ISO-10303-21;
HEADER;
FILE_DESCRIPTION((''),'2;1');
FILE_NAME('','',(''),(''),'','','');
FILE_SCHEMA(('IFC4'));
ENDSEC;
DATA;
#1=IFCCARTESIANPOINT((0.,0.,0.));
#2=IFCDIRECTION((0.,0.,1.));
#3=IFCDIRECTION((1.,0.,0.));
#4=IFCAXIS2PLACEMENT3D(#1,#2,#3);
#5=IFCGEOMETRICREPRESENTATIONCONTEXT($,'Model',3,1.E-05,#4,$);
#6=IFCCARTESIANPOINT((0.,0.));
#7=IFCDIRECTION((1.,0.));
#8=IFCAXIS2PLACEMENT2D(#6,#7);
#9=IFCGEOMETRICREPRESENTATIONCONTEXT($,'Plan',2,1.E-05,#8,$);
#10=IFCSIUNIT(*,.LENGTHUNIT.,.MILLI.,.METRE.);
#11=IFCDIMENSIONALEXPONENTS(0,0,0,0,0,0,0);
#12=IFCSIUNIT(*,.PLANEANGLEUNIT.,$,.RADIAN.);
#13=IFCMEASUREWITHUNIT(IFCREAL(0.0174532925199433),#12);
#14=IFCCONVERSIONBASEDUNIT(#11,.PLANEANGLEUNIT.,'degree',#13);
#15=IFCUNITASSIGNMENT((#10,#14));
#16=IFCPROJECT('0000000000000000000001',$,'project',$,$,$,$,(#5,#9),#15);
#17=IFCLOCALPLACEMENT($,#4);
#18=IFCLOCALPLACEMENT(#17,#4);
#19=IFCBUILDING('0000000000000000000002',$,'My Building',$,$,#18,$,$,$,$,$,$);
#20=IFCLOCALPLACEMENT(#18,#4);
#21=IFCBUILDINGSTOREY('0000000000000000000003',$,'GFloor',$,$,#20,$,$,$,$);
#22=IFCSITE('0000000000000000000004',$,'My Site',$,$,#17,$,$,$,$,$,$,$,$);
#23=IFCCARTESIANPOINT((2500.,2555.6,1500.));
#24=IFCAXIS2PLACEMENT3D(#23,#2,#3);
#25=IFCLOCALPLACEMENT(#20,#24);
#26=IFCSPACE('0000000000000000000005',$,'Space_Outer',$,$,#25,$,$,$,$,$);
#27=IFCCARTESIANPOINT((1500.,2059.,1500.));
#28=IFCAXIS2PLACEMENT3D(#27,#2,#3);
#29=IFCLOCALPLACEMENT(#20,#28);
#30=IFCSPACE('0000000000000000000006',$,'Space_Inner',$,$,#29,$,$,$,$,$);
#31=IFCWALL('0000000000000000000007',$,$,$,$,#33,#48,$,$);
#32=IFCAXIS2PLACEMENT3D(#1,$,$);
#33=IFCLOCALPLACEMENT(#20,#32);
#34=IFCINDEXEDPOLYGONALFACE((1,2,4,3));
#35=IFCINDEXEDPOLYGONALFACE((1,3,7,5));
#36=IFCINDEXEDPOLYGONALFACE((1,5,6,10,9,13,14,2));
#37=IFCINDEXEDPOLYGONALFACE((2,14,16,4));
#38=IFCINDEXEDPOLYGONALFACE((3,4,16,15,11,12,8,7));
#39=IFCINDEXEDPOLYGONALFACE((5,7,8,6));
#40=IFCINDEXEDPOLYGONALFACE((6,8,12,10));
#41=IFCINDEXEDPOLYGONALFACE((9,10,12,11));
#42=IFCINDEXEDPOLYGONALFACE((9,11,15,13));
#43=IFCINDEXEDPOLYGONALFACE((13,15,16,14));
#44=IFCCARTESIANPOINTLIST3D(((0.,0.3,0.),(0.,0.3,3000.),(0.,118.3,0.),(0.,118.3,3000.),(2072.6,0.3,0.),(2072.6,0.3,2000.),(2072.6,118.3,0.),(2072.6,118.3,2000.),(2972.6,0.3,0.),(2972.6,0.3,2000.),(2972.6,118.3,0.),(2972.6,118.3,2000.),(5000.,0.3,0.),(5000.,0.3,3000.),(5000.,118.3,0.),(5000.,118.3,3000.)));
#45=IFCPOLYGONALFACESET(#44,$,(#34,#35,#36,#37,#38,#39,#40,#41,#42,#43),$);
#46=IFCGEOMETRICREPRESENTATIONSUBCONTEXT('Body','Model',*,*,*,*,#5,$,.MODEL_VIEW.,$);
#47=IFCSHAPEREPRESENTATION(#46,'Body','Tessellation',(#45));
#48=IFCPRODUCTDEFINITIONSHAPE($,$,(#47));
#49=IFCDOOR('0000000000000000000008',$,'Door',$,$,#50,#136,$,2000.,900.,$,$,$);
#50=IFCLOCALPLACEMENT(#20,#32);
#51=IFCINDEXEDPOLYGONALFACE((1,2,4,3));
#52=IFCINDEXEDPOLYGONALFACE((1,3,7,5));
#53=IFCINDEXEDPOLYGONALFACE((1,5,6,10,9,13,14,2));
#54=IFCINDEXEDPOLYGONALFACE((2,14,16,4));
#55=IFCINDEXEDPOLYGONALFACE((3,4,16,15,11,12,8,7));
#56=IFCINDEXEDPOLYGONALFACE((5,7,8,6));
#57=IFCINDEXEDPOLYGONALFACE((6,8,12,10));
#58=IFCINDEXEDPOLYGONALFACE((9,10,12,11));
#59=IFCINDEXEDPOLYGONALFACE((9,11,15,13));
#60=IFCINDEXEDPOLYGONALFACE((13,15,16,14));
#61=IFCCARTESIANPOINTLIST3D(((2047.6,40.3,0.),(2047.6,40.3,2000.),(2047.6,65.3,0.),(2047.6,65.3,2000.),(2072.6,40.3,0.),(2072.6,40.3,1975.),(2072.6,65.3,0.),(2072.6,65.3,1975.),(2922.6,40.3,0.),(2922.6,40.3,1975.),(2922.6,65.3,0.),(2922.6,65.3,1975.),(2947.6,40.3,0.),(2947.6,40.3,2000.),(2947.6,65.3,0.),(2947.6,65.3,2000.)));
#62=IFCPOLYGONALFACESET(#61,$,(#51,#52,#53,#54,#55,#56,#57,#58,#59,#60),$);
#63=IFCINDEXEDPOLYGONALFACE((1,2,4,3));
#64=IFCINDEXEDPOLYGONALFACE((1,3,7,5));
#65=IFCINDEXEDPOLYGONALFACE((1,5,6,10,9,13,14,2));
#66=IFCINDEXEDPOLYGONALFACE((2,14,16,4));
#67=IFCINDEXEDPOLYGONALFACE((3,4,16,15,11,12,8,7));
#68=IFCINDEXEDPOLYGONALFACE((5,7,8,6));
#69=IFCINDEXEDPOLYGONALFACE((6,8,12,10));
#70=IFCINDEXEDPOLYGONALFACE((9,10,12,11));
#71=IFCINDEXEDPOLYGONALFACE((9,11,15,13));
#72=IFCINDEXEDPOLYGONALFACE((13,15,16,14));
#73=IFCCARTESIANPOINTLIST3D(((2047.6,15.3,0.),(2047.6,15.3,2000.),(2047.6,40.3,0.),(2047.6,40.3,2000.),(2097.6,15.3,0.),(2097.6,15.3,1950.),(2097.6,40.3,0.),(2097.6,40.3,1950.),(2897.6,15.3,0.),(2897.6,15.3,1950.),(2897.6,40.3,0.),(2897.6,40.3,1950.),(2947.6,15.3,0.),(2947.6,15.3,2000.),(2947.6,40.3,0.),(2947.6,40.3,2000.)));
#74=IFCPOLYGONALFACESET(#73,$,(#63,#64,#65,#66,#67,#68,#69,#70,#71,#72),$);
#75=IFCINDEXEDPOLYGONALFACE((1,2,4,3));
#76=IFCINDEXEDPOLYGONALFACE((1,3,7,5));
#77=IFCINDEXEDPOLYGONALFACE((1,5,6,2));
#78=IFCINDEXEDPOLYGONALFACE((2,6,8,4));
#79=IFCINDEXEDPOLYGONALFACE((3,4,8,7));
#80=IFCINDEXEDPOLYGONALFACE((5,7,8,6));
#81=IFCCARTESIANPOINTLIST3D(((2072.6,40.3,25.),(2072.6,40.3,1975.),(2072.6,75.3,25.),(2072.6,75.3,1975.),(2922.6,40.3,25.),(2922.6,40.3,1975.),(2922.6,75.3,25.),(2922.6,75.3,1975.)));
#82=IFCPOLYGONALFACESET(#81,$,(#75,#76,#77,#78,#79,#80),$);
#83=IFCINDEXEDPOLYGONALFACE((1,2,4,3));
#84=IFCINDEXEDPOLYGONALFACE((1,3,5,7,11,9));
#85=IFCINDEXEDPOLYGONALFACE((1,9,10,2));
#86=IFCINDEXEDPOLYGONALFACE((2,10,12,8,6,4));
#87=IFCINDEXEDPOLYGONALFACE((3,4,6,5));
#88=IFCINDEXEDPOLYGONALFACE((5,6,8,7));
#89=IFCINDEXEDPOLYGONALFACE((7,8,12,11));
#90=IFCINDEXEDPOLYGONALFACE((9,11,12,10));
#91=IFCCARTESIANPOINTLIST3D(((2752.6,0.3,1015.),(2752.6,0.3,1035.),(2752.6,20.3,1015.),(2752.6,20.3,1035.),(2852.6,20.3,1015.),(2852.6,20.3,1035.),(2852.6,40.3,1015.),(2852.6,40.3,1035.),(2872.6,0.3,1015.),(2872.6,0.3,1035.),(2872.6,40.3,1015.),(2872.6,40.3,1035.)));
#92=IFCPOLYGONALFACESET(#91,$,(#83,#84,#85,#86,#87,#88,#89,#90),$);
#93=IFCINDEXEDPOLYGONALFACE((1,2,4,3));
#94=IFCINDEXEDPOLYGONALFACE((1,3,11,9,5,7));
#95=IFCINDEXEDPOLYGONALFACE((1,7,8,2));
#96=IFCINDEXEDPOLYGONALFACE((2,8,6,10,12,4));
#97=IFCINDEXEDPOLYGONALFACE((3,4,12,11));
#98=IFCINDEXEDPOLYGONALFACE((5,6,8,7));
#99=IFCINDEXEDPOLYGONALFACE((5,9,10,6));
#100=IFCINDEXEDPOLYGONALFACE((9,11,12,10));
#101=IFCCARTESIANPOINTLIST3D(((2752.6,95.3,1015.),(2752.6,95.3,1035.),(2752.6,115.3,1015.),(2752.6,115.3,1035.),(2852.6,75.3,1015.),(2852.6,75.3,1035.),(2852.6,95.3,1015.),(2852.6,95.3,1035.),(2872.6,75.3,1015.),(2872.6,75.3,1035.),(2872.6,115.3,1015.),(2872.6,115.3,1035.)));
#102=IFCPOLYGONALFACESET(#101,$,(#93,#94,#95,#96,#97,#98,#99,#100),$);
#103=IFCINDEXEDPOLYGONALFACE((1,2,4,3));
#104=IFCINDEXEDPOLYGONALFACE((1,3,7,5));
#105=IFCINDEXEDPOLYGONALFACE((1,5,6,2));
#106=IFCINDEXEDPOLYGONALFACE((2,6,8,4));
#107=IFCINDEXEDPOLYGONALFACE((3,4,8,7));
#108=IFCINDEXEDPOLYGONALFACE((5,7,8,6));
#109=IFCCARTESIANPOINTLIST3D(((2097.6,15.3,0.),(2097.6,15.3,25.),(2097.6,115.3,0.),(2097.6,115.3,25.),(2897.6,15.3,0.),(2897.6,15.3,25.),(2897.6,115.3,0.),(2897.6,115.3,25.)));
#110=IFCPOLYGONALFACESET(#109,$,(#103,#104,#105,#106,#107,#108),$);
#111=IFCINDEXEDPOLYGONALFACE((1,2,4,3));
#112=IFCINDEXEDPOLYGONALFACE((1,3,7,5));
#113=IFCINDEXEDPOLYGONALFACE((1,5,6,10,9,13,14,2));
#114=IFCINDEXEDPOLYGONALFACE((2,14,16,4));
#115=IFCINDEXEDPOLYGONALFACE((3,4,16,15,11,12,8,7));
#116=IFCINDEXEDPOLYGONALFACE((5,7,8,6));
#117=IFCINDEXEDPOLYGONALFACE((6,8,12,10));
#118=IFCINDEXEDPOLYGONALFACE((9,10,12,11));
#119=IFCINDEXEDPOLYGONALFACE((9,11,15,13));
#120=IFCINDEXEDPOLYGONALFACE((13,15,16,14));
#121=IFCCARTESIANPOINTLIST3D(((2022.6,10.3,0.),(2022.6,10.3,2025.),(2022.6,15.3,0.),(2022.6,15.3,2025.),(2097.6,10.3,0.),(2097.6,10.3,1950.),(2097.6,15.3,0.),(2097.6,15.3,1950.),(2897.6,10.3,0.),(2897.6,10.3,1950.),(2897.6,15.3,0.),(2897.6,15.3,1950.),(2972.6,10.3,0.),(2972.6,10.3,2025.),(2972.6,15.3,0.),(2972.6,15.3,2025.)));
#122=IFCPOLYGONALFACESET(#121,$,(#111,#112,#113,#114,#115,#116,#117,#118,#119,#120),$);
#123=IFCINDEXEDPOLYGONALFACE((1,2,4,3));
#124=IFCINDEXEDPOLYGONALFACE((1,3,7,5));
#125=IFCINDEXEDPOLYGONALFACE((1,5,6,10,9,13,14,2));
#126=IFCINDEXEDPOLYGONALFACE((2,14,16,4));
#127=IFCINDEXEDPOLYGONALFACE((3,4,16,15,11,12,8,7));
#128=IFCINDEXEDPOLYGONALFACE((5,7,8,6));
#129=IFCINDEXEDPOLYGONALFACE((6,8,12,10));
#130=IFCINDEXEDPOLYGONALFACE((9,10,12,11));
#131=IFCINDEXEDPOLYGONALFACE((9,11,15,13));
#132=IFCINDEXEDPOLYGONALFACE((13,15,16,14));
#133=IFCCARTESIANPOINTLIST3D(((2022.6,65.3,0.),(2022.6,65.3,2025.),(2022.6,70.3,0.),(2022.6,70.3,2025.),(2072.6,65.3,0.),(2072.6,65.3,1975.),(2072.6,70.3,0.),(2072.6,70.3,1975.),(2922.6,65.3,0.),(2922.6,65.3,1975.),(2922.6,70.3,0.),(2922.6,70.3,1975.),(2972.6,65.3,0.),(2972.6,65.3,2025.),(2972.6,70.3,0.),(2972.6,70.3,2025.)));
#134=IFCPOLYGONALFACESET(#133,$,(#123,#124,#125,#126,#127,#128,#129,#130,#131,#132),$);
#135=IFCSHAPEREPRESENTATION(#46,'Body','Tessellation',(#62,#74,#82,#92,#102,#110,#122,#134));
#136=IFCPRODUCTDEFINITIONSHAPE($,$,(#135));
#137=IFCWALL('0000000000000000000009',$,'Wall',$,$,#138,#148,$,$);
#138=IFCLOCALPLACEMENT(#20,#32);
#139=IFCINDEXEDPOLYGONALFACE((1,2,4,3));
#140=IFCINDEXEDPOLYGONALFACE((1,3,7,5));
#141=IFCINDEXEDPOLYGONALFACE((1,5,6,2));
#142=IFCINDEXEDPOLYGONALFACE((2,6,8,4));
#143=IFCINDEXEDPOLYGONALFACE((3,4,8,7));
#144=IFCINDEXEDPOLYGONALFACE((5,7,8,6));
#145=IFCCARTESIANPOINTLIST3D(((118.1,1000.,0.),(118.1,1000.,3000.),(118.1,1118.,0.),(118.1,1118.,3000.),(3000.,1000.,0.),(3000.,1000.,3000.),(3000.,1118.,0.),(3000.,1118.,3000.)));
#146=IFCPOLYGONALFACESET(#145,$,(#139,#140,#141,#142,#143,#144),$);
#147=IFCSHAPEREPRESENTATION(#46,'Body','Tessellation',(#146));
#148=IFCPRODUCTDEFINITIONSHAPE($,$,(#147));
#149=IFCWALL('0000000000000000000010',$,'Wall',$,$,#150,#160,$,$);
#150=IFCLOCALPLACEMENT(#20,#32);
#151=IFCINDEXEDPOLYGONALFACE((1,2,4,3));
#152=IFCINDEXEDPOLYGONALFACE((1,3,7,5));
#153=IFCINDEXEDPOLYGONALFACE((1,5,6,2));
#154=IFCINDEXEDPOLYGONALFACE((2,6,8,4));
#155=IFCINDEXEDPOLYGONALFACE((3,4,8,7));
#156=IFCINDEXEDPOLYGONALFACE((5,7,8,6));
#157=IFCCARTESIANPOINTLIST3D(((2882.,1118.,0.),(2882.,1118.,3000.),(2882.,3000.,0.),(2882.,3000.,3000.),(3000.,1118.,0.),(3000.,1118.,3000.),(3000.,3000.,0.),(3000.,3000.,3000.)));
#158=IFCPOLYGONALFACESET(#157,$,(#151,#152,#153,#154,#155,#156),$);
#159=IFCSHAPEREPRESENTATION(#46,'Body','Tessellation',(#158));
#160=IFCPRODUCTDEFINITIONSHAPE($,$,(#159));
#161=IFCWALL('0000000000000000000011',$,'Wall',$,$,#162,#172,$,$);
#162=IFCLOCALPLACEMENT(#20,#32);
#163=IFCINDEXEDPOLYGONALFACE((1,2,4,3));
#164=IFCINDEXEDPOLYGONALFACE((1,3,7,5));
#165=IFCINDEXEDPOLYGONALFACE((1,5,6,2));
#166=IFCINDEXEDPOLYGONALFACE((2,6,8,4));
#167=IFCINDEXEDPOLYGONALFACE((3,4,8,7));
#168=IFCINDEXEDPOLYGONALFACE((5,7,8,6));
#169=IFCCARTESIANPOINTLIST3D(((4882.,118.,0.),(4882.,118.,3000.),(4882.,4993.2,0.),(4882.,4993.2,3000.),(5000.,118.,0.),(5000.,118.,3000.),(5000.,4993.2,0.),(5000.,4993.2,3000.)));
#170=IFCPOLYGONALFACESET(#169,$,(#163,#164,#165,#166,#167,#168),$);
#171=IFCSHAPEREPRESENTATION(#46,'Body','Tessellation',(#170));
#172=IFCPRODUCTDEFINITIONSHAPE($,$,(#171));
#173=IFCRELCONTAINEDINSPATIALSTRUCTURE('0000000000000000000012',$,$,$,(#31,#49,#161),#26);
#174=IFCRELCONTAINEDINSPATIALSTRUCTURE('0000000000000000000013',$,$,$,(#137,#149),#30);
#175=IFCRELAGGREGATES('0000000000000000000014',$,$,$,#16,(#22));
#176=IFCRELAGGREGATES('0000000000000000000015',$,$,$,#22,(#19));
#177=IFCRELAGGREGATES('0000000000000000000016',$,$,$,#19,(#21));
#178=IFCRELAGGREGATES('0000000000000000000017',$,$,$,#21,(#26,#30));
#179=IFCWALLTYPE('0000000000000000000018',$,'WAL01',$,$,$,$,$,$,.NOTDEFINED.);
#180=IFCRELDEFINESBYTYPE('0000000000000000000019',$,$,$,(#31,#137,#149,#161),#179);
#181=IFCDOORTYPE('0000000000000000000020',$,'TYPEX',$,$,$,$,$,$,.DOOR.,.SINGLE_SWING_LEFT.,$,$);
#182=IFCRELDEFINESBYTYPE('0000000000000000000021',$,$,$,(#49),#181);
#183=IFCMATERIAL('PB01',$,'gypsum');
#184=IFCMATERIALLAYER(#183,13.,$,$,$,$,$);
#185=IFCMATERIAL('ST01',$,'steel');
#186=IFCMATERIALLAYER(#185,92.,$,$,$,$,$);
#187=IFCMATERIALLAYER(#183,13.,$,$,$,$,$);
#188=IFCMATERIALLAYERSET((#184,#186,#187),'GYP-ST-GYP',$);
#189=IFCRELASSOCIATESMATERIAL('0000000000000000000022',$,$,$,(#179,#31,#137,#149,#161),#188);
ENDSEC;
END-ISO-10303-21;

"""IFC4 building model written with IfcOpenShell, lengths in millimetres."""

from ifc_helpers import new_model, entity, si_unit, converted_unit, frame, origin_with_axes, origin_2d_with_axis, place, context, subcontext, project, spatial, line, indexed_curve, outline, extrude, shape, source, transform, mapped, material, layer, layer_set, layer_usage, type_object, type_shapes, element, fill, save


model = new_model("IFC4")

# Units and contexts
model_context = context("Model", 3, precision=1e-05, world=origin_with_axes())
plan_context = context("Plan", 2, precision=1e-05, world=origin_2d_with_axis())
body_context_1 = subcontext(model_context, "Body", "Model", "MODEL_VIEW")
body_context_2 = subcontext(plan_context, "Body", "Plan", "PLAN_VIEW")
ifc_project = project(units=[si_unit("LENGTHUNIT", "METRE", prefix="MILLI"), converted_unit("PLANEANGLEUNIT", "degree", entity("IfcReal", 0.0174532925199433), si_unit("PLANEANGLEUNIT", "RADIAN"), dimensions=[0, 0, 0, 0, 0, 0, 0])], contexts=[model_context, plan_context])

# Site, building, storey
site_placement = place(None, origin_with_axes())
site = spatial("IfcSite", under=ifc_project, at=site_placement, Name="My Site")
building_placement = place(site_placement, origin_with_axes())
building = spatial("IfcBuilding", under=site, at=building_placement, Name="My Building")
storey_placement = place(building_placement, origin_with_axes())
storey = spatial("IfcBuildingStorey", under=building, at=storey_placement, Name="GFloor")

# Shared definitions
space_1_placement = place(storey_placement, frame((2500.0, 2555.6, 1500.0), z_axis=(0.0, 0.0, 1.0), x_axis=(1.0, 0.0, 0.0)))
space_1 = spatial("IfcSpace", under=storey, at=space_1_placement, Name="Space_Outer")

# Wall, opening, door
ifc_material_1 = material(Name="PB01", Category="gypsum")
ifc_layer_1 = layer(ifc_material_1, 13.0)
ifc_material_2 = material(Name="ST01", Category="steel")
ifc_layer_2 = layer(ifc_material_2, 92.0)
ifc_layer_3 = layer(ifc_material_1, 13.0)
ifc_layer_set_1 = layer_set([ifc_layer_1, ifc_layer_2, ifc_layer_3], Name="GYP-ST-GYP")
ifc_layer_usage_1 = layer_usage(ifc_layer_set_1, "AXIS2", "POSITIVE", 0.0)
wall_type_1 = type_object("IfcWallType", Name="WAL01", PredefinedType="NOTDEFINED", material=ifc_layer_set_1)
wall_1_placement = place(space_1_placement, frame((-2500.0, -2555.3, -1500.0), z_axis=(0.0, 0.0, 1.0), x_axis=(1.0, 0.0, 0.0)))
wall_1 = element("IfcWall", 1, at=wall_1_placement, inside=space_1, type_object=wall_type_1, material=ifc_layer_usage_1, context=body_context_1, shape_type="SweptSolid", body=[
    extrude(outline(indexed_curve([(0.0, 0.0), (0.0, 118.0), (5000.0, 118.0), (5000.0, 0.0), (0.0, 0.0)], self_intersect=False)), origin_with_axes(), (0.0, 0.0, 1.0), 3000.0),
])
shared_shape_1 = source(origin_with_axes(), body_context_1, "Body", "SweptSolid", [
    extrude(outline(indexed_curve([(0.0, 0.0), (900.0, 0.0), (900.0, 2000.0), (0.0, 2000.0)], segments=[line(1, 2, 3, 4, 1)])), frame((0.0, -600.0, 0.0), z_axis=(0.0, -1.0, 0.0), x_axis=(1.0, 0.0, 0.0)), (0.0, 0.0, -1.0), 1200.0),
])
opening_placement = place(wall_1_placement, frame((2072.6, 0.0, 0.0), z_axis=(0.0, 0.0, 1.0), x_axis=(1.0, 0.0, 0.0)))
opening = element("IfcOpeningElement", 2, at=opening_placement, cuts=wall_1, PredefinedType="OPENING", context=body_context_1, shape_type="MappedRepresentation", body=[
    mapped(shared_shape_1, transform((0.0, 0.0, 0.0), x_axis=(1.0, 0.0, 0.0), y_axis=(0.0, 1.0, 0.0), z_axis=(0.0, 0.0, 1.0), scale=1.0)),
])
door_type = type_object("IfcDoorType", Name="TYPEX", OperationType="SINGLE_SWING_LEFT", PredefinedType="DOOR")
shared_shape_2 = source(origin_with_axes(), body_context_1, "Body", "SweptSolid", [
    extrude(outline(indexed_curve([(0.0, 0.0), (0.0, 2000.0), (900.0, 2000.0), (900.0, 0.0), (875.0, 0.0), (875.0, 1975.0), (25.0, 1975.0), (25.0, 0.0)], segments=[line(1, 2, 3, 4, 5, 6, 7, 8, 1)])), frame((0.0, 25.0, 0.0), z_axis=(0.0, -1.0, 0.0), x_axis=(1.0, 0.0, 0.0)), (0.0, 0.0, -1.0), 25.0),
    extrude(outline(indexed_curve([(0.0, 0.0), (0.0, 2000.0), (900.0, 2000.0), (900.0, 0.0), (850.0, 0.0), (850.0, 1950.0), (50.0, 1950.0), (50.0, 0.0)], segments=[line(1, 2, 3, 4, 5, 6, 7, 8, 1)])), frame((0.0, 0.0, 0.0), z_axis=(0.0, -1.0, 0.0), x_axis=(1.0, 0.0, 0.0)), (0.0, 0.0, -1.0), 25.0),
    extrude(outline(indexed_curve([(0.0, 0.0), (850.0, 0.0), (850.0, 35.0), (0.0, 35.0)], segments=[line(1, 2, 3, 4, 1)])), frame((25.0, 25.0, 25.0), z_axis=(0.0, 0.0, 1.0), x_axis=(1.0, 0.0, 0.0)), (0.0, 0.0, 1.0), 1950.0),
    extrude(outline(indexed_curve([(0.0, 0.0), (0.0, -40.0), (-120.0, -40.0), (-120.0, -20.0), (-20.0, -20.0), (-20.0, 0.0)], segments=[line(1, 2, 3, 4, 5, 6, 1)])), frame((825.0, 25.0, 1015.0), z_axis=(0.0, 0.0, 1.0), x_axis=(1.0, 0.0, 0.0)), (0.0, 0.0, 1.0), 20.0),
    extrude(outline(indexed_curve([(0.0, 0.0), (0.0, 40.0), (-120.0, 40.0), (-120.0, 20.0), (-20.0, 20.0), (-20.0, 0.0)], segments=[line(1, 2, 3, 4, 5, 6, 1)])), frame((825.0, 60.0, 1015.0), z_axis=(0.0, 0.0, 1.0), x_axis=(1.0, 0.0, 0.0)), (0.0, 0.0, 1.0), 20.0),
    extrude(outline(indexed_curve([(0.0, 0.0), (800.0, 0.0), (800.0, 100.0), (0.0, 100.0)], segments=[line(1, 2, 3, 4, 1)])), frame((50.0, 0.0, 0.0), z_axis=(0.0, 0.0, 1.0), x_axis=(1.0, 0.0, 0.0)), (0.0, 0.0, 1.0), 25.0),
    extrude(outline(indexed_curve([(0.0, 0.0), (0.0, 2025.0), (950.0, 2025.0), (950.0, 0.0), (875.0, 0.0), (875.0, 1950.0), (75.0, 1950.0), (75.0, 0.0)], segments=[line(1, 2, 3, 4, 5, 6, 7, 8, 1)])), frame((-25.0, -5.0, 0.0), z_axis=(0.0, -1.0, 0.0), x_axis=(1.0, 0.0, 0.0)), (0.0, 0.0, -1.0), 5.0),
    extrude(outline(indexed_curve([(0.0, 0.0), (0.0, 2025.0), (950.0, 2025.0), (950.0, 0.0), (900.0, 0.0), (900.0, 1975.0), (50.0, 1975.0), (50.0, 0.0)], segments=[line(1, 2, 3, 4, 5, 6, 7, 8, 1)])), frame((-25.0, 50.0, 0.0), z_axis=(0.0, -1.0, 0.0), x_axis=(1.0, 0.0, 0.0)), (0.0, 0.0, -1.0), 5.0),
])
shared_shape_3 = source(origin_with_axes(), body_context_2, "Body", "Curve2D", [
    entity("IfcIndexedPolyCurve", entity("IfcCartesianPointList2D", [[0.0, 0.0], [0.0, 50.0], [25.0, 50.0], [25.0, 25.0], [50.0, 25.0], [50.0, 0.0]]), [entity("IfcLineIndex", [1, 2, 3, 4, 5, 6, 1])]),
    entity("IfcIndexedPolyCurve", entity("IfcCartesianPointList2D", [[900.0, 0.0], [900.0, 50.0], [875.0, 50.0], [875.0, 25.0], [850.0, 25.0], [850.0, 0.0]]), [entity("IfcLineIndex", [1, 2, 3, 4, 5, 6, 1])]),
    entity("IfcTrimmedCurve", entity("IfcEllipse", entity("IfcAxis2Placement2D", entity("IfcCartesianPoint", [60.0, 50.0]), entity("IfcDirection", [1.0, 0.0])), 815.0, 850.0), [entity("IfcCartesianPoint", [875.0, 50.0])], [entity("IfcCartesianPoint", [60.0, 900.0])], True, "CARTESIAN"),
    entity("IfcIndexedPolyCurve", entity("IfcCartesianPointList2D", [[25.0, 50.0], [60.0, 50.0], [60.0, 900.0], [25.0, 900.0]]), [entity("IfcLineIndex", [1, 2, 3, 4, 1])]),
])
type_shapes(door_type, [shared_shape_2, shared_shape_3])
door_1_placement = place(opening_placement, frame((-25.0, 15.0, 0.0), z_axis=(0.0, 0.0, 1.0), x_axis=(1.0, 0.0, 0.0)))
door_1 = element("IfcDoor", 3, at=door_1_placement, inside=space_1, type_object=door_type, Name="Door", OverallHeight=2000.0, OverallWidth=900.0, shapes=[
    shape(body_context_1, "Body", "MappedRepresentation", [mapped(shared_shape_2, transform((0.0, 0.0, 0.0), x_axis=(1.0, 0.0, 0.0), y_axis=(0.0, 1.0, 0.0), z_axis=(0.0, 0.0, 1.0), scale=1.0))]),
    shape(body_context_2, "Body", "MappedRepresentation", [mapped(shared_shape_3, transform((0.0, 0.0, 0.0), x_axis=(1.0, 0.0, 0.0), y_axis=(0.0, 1.0, 0.0), z_axis=(0.0, 0.0, 1.0), scale=1.0))]),
])
fill(opening, door_1)

# Shared definitions
space_2_placement = place(storey_placement, frame((1500.0, 2059.0, 1500.0), z_axis=(0.0, 0.0, 1.0), x_axis=(1.0, 0.0, 0.0)))
space_2 = spatial("IfcSpace", under=storey, at=space_2_placement, Name="Space_Inner")

# Walls
ifc_layer_usage_2 = layer_usage(ifc_layer_set_1, "AXIS2", "POSITIVE", 0.0)
wall_2_placement = place(space_2_placement, frame((-1381.9, -1059.0, -1500.0), z_axis=(0.0, 0.0, 1.0), x_axis=(1.0, 0.0, 0.0)))
element("IfcWall", 4, at=wall_2_placement, inside=space_2, type_object=wall_type_1, material=ifc_layer_usage_2, Name="Wall", context=body_context_1, shape_type="SweptSolid", body=[
    extrude(outline(indexed_curve([(0.0, 0.0), (0.0, 118.0), (2881.9, 118.0), (2881.9, 0.0), (0.0, 0.0)], self_intersect=False)), origin_with_axes(), (0.0, 0.0, 1.0), 3000.0),
])
ifc_layer_usage_3 = layer_usage(ifc_layer_set_1, "AXIS2", "POSITIVE", 0.0)
wall_3_placement = place(space_2_placement, frame((1500.0, -941.0, -1500.0), z_axis=(0.0, 0.0, 1.0), x_axis=(0.0, 1.0, 0.0)))
element("IfcWall", 5, at=wall_3_placement, inside=space_2, type_object=wall_type_1, material=ifc_layer_usage_3, Name="Wall", context=body_context_1, shape_type="SweptSolid", body=[
    extrude(outline(indexed_curve([(0.0, 0.0), (0.0, 118.0), (1882.0, 118.0), (1882.0, 0.0), (0.0, 0.0)], self_intersect=False)), origin_with_axes(), (0.0, 0.0, 1.0), 3000.0),
])
ifc_layer_usage_4 = layer_usage(ifc_layer_set_1, "AXIS2", "POSITIVE", 0.0)
wall_4_placement = place(space_1_placement, frame((2500.0, -2437.6, -1500.0), z_axis=(0.0, 0.0, 1.0), x_axis=(0.0, 1.0, 0.0)))
element("IfcWall", 6, at=wall_4_placement, inside=space_1, type_object=wall_type_1, material=ifc_layer_usage_4, Name="Wall", context=body_context_1, shape_type="SweptSolid", body=[
    extrude(outline(indexed_curve([(0.0, 0.0), (0.0, 118.0), (4875.2, 118.0), (4875.2, 0.0), (0.0, 0.0)], self_intersect=False)), origin_with_axes(), (0.0, 0.0, 1.0), 3000.0),
])

save(model, "model.ifc")
